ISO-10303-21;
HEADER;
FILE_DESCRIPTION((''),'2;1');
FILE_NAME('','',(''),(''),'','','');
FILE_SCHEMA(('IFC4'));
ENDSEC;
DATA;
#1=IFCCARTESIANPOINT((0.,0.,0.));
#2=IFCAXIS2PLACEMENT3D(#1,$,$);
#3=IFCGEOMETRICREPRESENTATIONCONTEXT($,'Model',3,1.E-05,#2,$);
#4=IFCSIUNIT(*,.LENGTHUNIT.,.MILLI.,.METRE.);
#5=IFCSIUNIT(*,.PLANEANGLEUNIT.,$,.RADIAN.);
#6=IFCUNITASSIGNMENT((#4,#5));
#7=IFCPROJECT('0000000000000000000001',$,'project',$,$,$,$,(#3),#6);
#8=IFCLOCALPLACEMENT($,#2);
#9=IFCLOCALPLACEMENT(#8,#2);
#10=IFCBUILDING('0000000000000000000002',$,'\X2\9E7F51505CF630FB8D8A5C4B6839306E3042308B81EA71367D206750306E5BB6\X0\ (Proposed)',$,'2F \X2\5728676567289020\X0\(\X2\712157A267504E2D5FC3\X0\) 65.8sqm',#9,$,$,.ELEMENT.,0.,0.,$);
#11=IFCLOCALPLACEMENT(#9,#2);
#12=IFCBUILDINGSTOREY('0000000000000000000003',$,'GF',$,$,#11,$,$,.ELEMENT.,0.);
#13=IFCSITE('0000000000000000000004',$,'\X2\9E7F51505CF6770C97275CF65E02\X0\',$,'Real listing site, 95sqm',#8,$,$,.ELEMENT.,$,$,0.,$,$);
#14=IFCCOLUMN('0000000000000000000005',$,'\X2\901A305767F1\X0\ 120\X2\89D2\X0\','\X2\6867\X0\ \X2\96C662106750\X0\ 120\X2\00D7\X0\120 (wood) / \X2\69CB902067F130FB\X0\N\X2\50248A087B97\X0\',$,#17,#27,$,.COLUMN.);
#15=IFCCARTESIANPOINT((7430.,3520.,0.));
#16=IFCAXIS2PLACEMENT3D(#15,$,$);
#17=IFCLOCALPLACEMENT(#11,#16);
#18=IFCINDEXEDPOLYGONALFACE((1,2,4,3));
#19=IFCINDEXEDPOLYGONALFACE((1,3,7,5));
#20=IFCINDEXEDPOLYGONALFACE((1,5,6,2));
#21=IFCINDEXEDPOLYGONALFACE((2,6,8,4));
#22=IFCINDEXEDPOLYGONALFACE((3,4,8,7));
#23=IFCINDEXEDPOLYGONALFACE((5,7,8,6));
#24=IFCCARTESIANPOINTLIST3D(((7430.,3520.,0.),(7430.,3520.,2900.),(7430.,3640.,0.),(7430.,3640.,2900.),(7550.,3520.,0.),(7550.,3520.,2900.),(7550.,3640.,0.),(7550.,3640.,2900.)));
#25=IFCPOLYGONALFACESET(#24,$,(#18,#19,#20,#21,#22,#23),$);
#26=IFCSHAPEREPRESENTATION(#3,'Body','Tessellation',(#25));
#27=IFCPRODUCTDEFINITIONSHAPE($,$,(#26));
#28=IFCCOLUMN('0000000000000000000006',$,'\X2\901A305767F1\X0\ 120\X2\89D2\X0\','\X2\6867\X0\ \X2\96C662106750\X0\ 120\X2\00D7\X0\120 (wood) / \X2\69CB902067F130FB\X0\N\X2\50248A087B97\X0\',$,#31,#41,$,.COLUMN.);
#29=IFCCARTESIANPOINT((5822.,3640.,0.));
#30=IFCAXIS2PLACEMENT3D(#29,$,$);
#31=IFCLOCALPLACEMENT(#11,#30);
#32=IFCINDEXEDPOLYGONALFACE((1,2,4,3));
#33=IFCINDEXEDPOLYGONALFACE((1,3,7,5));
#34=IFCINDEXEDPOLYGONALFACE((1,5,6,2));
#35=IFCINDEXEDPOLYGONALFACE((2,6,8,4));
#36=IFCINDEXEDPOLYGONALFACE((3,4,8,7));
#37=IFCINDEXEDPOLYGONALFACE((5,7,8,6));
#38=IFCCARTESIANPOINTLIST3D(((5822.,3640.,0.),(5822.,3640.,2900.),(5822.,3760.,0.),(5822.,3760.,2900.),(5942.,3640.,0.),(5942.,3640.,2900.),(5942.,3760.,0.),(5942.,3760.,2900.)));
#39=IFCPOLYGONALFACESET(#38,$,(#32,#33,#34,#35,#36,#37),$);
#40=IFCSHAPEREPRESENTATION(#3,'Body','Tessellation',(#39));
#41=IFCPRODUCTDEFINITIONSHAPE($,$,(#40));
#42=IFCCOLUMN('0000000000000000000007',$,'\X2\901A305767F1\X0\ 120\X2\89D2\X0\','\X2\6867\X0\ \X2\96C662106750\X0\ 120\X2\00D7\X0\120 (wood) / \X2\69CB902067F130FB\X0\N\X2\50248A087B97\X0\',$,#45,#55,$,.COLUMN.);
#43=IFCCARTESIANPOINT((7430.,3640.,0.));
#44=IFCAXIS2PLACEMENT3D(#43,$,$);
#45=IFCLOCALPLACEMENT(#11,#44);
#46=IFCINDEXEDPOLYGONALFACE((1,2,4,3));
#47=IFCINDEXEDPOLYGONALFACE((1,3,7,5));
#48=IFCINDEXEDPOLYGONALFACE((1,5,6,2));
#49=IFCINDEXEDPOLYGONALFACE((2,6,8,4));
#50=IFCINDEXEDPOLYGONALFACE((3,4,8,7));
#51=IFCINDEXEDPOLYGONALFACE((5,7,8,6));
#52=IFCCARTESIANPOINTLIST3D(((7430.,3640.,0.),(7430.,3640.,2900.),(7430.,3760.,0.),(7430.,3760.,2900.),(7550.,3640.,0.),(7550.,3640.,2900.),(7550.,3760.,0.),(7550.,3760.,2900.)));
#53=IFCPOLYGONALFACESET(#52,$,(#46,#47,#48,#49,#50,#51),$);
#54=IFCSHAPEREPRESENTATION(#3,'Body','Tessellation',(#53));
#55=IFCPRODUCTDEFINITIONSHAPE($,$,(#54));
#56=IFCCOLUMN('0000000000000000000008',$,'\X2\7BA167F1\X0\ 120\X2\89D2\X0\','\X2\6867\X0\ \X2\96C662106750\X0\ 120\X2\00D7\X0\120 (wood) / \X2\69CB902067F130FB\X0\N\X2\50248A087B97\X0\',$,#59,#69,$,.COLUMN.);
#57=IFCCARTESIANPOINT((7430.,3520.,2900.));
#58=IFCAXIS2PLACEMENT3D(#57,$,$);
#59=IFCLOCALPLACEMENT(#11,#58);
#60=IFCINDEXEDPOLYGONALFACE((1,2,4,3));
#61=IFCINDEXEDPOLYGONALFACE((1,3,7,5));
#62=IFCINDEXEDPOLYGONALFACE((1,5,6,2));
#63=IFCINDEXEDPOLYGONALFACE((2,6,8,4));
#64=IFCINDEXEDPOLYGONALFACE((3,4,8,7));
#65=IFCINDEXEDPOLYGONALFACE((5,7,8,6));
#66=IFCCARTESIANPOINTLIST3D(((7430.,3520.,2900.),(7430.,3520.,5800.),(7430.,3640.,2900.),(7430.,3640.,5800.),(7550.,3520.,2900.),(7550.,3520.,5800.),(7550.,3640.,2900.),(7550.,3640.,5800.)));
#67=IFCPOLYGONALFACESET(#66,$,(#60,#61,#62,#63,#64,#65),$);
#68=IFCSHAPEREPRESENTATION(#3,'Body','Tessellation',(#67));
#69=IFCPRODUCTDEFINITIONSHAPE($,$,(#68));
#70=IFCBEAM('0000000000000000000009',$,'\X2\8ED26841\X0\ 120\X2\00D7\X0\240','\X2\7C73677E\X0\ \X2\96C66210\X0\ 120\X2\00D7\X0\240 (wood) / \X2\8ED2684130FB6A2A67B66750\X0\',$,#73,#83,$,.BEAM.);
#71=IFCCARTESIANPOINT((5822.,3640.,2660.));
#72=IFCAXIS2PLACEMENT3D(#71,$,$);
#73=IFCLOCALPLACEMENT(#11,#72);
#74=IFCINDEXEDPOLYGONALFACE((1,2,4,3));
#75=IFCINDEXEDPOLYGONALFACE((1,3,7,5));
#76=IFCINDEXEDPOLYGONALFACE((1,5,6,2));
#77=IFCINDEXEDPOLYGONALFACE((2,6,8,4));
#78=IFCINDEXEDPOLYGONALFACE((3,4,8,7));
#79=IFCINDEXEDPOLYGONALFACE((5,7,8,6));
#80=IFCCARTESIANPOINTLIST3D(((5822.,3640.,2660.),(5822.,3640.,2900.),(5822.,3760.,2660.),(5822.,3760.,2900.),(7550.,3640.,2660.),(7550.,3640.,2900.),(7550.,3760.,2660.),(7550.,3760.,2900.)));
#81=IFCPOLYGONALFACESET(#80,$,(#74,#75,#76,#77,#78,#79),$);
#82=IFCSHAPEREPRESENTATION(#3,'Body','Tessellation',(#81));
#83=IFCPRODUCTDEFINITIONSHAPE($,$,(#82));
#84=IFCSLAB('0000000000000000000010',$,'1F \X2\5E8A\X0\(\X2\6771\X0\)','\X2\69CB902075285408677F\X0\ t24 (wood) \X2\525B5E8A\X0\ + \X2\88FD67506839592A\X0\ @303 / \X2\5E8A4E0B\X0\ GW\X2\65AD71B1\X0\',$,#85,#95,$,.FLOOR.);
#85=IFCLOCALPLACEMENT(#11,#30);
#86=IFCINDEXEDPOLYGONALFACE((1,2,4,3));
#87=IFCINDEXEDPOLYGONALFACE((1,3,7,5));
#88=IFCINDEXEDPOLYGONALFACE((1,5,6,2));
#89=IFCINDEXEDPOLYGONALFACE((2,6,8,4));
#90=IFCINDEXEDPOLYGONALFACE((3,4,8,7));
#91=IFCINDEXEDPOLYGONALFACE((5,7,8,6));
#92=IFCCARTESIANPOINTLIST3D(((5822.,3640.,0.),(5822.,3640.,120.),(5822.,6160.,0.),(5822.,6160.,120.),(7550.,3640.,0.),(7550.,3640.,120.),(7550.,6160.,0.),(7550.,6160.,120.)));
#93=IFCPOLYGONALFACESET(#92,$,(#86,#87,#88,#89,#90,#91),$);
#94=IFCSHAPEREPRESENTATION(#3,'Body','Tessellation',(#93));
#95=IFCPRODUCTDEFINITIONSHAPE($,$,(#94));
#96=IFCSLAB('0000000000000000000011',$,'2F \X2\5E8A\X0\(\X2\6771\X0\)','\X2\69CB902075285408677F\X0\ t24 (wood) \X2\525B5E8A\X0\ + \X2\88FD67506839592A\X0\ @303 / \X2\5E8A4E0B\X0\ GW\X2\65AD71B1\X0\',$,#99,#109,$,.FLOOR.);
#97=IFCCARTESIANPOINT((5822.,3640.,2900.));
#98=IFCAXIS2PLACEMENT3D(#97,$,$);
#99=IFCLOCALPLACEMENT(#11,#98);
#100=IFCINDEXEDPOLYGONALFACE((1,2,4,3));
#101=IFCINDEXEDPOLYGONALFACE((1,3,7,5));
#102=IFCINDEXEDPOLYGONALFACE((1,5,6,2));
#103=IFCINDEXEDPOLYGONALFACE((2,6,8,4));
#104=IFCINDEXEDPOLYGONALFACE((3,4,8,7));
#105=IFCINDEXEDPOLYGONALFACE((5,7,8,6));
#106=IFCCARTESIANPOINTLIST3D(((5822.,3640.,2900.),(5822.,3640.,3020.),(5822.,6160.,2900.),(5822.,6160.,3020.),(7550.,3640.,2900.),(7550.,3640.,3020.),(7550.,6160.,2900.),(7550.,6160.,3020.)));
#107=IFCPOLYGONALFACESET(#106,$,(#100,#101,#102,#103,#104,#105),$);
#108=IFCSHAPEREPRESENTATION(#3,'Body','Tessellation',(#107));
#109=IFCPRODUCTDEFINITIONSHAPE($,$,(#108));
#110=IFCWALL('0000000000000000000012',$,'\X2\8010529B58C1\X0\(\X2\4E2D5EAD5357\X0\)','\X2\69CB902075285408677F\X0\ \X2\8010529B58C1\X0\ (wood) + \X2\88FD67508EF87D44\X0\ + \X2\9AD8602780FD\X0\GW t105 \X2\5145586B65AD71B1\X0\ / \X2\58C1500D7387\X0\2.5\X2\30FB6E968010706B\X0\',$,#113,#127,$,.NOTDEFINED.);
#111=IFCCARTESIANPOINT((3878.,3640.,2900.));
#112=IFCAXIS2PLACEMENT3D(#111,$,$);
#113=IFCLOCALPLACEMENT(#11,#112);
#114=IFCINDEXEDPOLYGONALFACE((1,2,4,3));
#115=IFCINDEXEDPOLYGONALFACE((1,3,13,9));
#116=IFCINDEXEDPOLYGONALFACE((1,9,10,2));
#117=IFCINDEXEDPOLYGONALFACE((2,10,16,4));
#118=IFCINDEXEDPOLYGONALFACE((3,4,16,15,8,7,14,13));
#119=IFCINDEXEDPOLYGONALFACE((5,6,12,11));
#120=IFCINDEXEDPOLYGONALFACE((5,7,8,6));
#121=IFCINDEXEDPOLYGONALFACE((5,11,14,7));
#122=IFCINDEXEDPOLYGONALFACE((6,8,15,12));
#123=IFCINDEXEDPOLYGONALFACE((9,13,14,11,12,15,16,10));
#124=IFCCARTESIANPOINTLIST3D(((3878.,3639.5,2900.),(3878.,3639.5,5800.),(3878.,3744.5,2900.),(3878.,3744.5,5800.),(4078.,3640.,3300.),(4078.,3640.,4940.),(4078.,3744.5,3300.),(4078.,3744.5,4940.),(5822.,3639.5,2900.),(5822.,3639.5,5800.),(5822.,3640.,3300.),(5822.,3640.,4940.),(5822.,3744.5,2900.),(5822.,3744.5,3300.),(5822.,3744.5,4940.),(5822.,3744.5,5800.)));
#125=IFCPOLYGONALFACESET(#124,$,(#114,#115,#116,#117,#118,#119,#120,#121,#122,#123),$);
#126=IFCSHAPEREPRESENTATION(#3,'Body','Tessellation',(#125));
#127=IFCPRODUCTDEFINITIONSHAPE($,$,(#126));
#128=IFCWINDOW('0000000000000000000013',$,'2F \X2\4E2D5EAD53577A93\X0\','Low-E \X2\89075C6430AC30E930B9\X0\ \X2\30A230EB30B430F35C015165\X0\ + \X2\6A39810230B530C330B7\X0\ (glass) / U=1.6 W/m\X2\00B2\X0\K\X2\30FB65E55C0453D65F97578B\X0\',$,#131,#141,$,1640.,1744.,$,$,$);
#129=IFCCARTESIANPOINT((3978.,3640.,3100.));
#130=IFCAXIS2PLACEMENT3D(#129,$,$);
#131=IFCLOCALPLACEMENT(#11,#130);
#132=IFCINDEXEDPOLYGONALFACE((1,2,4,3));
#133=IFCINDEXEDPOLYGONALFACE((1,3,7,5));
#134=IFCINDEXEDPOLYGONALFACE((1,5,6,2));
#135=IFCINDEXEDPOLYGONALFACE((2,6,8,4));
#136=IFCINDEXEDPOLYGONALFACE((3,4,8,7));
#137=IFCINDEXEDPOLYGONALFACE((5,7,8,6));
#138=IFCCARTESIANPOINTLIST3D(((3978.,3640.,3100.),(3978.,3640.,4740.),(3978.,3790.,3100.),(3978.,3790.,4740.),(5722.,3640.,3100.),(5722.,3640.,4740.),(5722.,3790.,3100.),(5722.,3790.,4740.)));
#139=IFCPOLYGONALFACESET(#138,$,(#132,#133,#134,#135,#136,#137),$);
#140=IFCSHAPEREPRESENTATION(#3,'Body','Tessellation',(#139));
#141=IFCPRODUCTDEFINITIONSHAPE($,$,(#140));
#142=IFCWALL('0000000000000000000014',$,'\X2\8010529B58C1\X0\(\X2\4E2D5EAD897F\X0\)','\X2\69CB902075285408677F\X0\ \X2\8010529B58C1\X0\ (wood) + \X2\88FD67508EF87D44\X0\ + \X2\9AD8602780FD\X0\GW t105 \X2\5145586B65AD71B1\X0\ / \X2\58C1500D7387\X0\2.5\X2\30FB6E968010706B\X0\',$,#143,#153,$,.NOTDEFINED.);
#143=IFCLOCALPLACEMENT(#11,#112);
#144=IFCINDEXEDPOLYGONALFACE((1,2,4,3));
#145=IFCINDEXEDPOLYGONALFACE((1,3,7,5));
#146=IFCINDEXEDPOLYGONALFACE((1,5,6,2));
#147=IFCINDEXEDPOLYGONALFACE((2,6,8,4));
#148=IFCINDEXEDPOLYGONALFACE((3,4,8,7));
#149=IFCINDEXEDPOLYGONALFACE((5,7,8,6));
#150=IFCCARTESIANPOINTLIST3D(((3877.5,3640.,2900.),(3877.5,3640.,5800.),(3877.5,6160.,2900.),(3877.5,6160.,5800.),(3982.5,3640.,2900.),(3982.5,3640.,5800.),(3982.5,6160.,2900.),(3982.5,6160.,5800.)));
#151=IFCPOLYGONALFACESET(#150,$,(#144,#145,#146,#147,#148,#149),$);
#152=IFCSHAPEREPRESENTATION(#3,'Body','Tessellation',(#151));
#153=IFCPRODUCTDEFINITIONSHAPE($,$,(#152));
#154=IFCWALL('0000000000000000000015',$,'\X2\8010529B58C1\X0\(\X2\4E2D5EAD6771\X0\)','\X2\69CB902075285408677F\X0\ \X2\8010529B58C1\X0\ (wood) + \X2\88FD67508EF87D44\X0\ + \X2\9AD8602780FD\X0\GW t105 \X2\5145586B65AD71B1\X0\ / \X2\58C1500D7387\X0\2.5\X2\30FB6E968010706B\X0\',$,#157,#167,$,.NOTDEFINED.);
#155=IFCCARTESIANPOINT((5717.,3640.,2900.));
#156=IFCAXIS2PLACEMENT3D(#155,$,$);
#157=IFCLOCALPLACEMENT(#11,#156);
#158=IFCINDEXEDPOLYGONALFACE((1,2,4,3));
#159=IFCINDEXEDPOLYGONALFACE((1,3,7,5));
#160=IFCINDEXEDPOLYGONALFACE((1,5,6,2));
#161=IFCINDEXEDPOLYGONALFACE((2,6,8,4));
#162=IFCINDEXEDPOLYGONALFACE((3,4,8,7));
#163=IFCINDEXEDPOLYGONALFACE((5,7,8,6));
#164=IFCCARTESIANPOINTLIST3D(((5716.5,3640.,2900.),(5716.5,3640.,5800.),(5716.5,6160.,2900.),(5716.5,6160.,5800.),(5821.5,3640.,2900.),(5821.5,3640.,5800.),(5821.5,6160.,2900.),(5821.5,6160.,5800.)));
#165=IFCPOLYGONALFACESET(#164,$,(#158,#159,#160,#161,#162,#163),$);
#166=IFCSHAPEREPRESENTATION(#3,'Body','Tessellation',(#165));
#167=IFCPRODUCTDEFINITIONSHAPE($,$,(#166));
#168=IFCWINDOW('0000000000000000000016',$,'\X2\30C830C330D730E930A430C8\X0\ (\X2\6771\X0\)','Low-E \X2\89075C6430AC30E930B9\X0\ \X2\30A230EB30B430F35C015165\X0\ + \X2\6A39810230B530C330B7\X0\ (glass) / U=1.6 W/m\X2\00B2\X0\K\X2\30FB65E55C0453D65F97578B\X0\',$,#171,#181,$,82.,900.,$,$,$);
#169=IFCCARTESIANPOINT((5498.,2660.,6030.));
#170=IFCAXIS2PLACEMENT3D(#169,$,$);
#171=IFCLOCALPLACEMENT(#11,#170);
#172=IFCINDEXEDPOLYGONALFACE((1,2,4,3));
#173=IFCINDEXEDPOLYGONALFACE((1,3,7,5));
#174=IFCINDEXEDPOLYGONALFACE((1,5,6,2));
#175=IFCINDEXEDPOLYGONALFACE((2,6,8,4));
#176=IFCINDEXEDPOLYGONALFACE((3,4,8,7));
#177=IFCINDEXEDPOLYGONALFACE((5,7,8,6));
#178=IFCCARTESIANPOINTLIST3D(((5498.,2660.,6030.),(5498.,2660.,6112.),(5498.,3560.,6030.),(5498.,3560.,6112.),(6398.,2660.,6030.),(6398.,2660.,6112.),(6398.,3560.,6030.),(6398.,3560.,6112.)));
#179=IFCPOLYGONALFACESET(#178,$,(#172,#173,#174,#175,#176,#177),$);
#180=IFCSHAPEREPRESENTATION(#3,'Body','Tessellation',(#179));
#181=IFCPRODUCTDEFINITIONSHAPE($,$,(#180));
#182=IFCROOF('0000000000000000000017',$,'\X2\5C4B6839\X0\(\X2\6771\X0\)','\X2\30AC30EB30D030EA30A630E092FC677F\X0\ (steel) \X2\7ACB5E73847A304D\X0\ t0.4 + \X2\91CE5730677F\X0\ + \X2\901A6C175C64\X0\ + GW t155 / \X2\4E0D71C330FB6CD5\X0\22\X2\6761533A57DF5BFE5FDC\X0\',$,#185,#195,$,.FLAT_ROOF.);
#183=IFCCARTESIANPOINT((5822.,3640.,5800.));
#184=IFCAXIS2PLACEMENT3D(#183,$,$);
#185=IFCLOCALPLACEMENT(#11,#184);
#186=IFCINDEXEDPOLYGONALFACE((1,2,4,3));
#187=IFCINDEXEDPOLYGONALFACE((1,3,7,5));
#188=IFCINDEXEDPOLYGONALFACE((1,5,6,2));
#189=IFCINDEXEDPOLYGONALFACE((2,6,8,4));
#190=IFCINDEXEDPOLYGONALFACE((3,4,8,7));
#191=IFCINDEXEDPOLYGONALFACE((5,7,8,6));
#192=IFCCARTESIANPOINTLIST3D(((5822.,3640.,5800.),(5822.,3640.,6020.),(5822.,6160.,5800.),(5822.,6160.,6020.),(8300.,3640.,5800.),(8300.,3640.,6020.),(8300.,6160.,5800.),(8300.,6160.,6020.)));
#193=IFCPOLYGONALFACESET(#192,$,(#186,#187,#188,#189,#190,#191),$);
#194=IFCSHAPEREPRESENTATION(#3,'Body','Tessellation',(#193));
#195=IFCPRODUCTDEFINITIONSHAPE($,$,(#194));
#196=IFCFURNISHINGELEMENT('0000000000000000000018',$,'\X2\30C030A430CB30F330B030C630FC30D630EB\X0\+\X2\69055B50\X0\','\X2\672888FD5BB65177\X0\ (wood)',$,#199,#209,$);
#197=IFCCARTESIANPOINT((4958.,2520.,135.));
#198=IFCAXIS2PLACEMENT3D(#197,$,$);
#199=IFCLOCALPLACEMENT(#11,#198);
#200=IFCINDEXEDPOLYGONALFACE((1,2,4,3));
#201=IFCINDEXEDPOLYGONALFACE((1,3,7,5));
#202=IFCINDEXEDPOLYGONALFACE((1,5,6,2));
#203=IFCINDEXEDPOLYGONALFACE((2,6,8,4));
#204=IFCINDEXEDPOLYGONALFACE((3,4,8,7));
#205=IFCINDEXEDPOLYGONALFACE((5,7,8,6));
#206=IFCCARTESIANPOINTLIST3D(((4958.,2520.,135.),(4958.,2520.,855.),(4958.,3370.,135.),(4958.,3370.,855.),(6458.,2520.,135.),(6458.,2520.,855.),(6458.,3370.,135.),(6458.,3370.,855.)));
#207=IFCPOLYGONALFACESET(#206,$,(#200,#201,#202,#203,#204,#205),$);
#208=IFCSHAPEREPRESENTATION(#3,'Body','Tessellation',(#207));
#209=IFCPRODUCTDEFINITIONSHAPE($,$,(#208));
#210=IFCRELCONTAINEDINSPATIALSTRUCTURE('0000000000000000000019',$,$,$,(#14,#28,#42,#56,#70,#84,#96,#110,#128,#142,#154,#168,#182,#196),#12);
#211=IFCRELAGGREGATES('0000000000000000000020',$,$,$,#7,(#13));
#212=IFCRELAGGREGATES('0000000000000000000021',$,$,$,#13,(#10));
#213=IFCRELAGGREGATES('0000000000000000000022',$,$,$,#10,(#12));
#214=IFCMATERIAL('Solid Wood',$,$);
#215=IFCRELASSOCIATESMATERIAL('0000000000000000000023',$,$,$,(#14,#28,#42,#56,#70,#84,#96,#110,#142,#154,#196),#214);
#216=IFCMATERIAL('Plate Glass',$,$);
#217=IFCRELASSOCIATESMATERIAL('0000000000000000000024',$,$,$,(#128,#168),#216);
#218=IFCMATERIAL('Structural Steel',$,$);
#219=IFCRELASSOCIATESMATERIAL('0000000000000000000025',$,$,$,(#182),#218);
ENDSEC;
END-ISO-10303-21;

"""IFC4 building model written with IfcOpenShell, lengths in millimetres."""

from ifc_helpers import new_model, si_unit, frame, frame_2d, origin, place, context, project, spatial, rectangle, extrude, material, element, fill, save


model = new_model("IFC4")

# Units and contexts
model_context = context("Model", 3, precision=1e-05, world=origin())
ifc_project = project(units=[si_unit("LENGTHUNIT", "METRE", prefix="MILLI"), si_unit("PLANEANGLEUNIT", "RADIAN")], contexts=[model_context])

# Site, building, storey
site_placement = place(None, origin())
site = spatial("IfcSite", under=ifc_project, at=site_placement, Name="鹿児島県霧島市", ObjectType="Real listing site, 95sqm", CompositionType="ELEMENT", RefElevation=0.0)
building_placement = place(site_placement, origin())
building = spatial("IfcBuilding", under=site, at=building_placement, Name="鹿児島・越屋根のある自然素材の家 (Proposed)", ObjectType="2F 在来木造(無垢材中心) 65.8sqm", CompositionType="ELEMENT", ElevationOfRefHeight=0.0, ElevationOfTerrain=0.0)
storey_placement = place(building_placement, origin())
storey = spatial("IfcBuildingStorey", under=building, at=storey_placement, Name="GF", CompositionType="ELEMENT", Elevation=0.0)

# Columns
ifc_material_1 = material(Name="Solid Wood")
column_1_placement = place(storey_placement, frame((7430.0, 3520.0, 0.0)))
element("IfcColumn", 1, at=column_1_placement, inside=storey, material=ifc_material_1, Name="通し柱 120角", Description="桧 集成材 120×120 (wood) / 構造柱・N値計算", PredefinedType="COLUMN", context=model_context, shape_type="SweptSolid", body=[
    extrude(rectangle(XDim=120.0, YDim=120.0, at=frame_2d((60.0, 60.0))), frame((7430.0, 3520.0, 0.0)), (0.0, 0.0, 1.0), 2900.0),
])
column_2_placement = place(storey_placement, frame((5822.0, 3640.0, 0.0)))
element("IfcColumn", 2, at=column_2_placement, inside=storey, material=ifc_material_1, Name="通し柱 120角", Description="桧 集成材 120×120 (wood) / 構造柱・N値計算", PredefinedType="COLUMN", context=model_context, shape_type="SweptSolid", body=[
    extrude(rectangle(XDim=120.0, YDim=120.0, at=frame_2d((60.0, 60.0))), frame((5822.0, 3640.0, 0.0)), (0.0, 0.0, 1.0), 2900.0),
])
column_3_placement = place(storey_placement, frame((7430.0, 3640.0, 0.0)))
element("IfcColumn", 3, at=column_3_placement, inside=storey, material=ifc_material_1, Name="通し柱 120角", Description="桧 集成材 120×120 (wood) / 構造柱・N値計算", PredefinedType="COLUMN", context=model_context, shape_type="SweptSolid", body=[
    extrude(rectangle(XDim=120.0, YDim=120.0, at=frame_2d((60.0, 60.0))), frame((7430.0, 3640.0, 0.0)), (0.0, 0.0, 1.0), 2900.0),
])
column_4_placement = place(storey_placement, frame((7430.0, 3520.0, 2900.0)))
element("IfcColumn", 4, at=column_4_placement, inside=storey, material=ifc_material_1, Name="管柱 120角", Description="桧 集成材 120×120 (wood) / 構造柱・N値計算", PredefinedType="COLUMN", context=model_context, shape_type="SweptSolid", body=[
    extrude(rectangle(XDim=120.0, YDim=120.0, at=frame_2d((60.0, 60.0))), frame((7430.0, 3520.0, 2900.0)), (0.0, 0.0, 1.0), 2900.0),
])

# Beam
beam_1_placement = place(storey_placement, frame((5822.0, 3640.0, 2660.0)))
element("IfcBeam", 5, at=beam_1_placement, inside=storey, material=ifc_material_1, Name="軒桁 120×240", Description="米松 集成 120×240 (wood) / 軒桁・横架材", PredefinedType="BEAM", context=model_context, shape_type="SweptSolid", body=[
    extrude(rectangle(XDim=1728.0, YDim=120.0, at=frame_2d((864.0, 60.0))), frame((5822.0, 3640.0, 2660.0)), (0.0, 0.0, 1.0), 240.0),
])

# Slabs
slab_1_placement = place(storey_placement, frame((5822.0, 3640.0, 0.0)))
element("IfcSlab", 6, at=slab_1_placement, inside=storey, material=ifc_material_1, Name="1F 床(東)", Description="構造用合板 t24 (wood) 剛床 + 製材根太 @303 / 床下 GW断熱", PredefinedType="FLOOR", context=model_context, shape_type="SweptSolid", body=[
    extrude(rectangle(XDim=1728.0, YDim=2520.0, at=frame_2d((864.0, 1260.0))), frame((5822.0, 3640.0, 0.0)), (0.0, 0.0, 1.0), 120.0),
])
slab_2_placement = place(storey_placement, frame((5822.0, 3640.0, 2900.0)))
element("IfcSlab", 7, at=slab_2_placement, inside=storey, material=ifc_material_1, Name="2F 床(東)", Description="構造用合板 t24 (wood) 剛床 + 製材根太 @303 / 床下 GW断熱", PredefinedType="FLOOR", context=model_context, shape_type="SweptSolid", body=[
    extrude(rectangle(XDim=1728.0, YDim=2520.0, at=frame_2d((864.0, 1260.0))), frame((5822.0, 3640.0, 2900.0)), (0.0, 0.0, 1.0), 120.0),
])

# Wall, opening, window
wall_1_placement = place(storey_placement, frame((3878.0, 3640.0, 2900.0)))
wall_1 = element("IfcWall", 8, at=wall_1_placement, inside=storey, material=ifc_material_1, Name="耐力壁(中庭南)", Description="構造用合板 耐力壁 (wood) + 製材軸組 + 高性能GW t105 充填断熱 / 壁倍率2.5・準耐火", PredefinedType="NOTDEFINED", context=model_context, shape_type="SweptSolid", body=[
    extrude(rectangle(XDim=1944.0, YDim=105.0, at=frame_2d((972.0, 52.0))), frame((3878.0, 3640.0, 2900.0)), (0.0, 0.0, 1.0), 2900.0),
])
opening_placement = place(storey_placement, frame((3978.0, 3640.0, 3100.0)))
opening = element("IfcOpeningElement", 9, at=opening_placement, cuts=wall_1, PredefinedType="NOTDEFINED", context=model_context, shape_type="SweptSolid", body=[
    extrude(rectangle(XDim=1744.0, YDim=150.0, at=frame_2d((872.0, 75.0))), frame((3978.0, 3640.0, 3100.0)), (0.0, 0.0, 1.0), 1640.0),
])
ifc_material_2 = material(Name="Plate Glass")
window_1_placement = place(storey_placement, frame((3978.0, 3640.0, 3100.0)))
window_1 = element("IfcWindow", 10, at=window_1_placement, inside=storey, material=ifc_material_2, Name="2F 中庭南窓", Description="Low-E 複層ガラス アルゴン封入 + 樹脂サッシ (glass) / U=1.6 W/m²K・日射取得型", OverallHeight=1640.0, OverallWidth=1744.0, context=model_context, shape_type="SweptSolid", body=[
    extrude(rectangle(XDim=1744.0, YDim=150.0, at=frame_2d((872.0, 75.0))), frame((3978.0, 3640.0, 3100.0)), (0.0, 0.0, 1.0), 1640.0),
])
fill(opening, window_1)

# Walls
wall_2_placement = place(storey_placement, frame((3878.0, 3640.0, 2900.0)))
element("IfcWall", 11, at=wall_2_placement, inside=storey, material=ifc_material_1, Name="耐力壁(中庭西)", Description="構造用合板 耐力壁 (wood) + 製材軸組 + 高性能GW t105 充填断熱 / 壁倍率2.5・準耐火", PredefinedType="NOTDEFINED", context=model_context, shape_type="SweptSolid", body=[
    extrude(rectangle(XDim=105.0, YDim=2520.0, at=frame_2d((52.0, 1260.0))), frame((3878.0, 3640.0, 2900.0)), (0.0, 0.0, 1.0), 2900.0),
])
wall_3_placement = place(storey_placement, frame((5717.0, 3640.0, 2900.0)))
element("IfcWall", 12, at=wall_3_placement, inside=storey, material=ifc_material_1, Name="耐力壁(中庭東)", Description="構造用合板 耐力壁 (wood) + 製材軸組 + 高性能GW t105 充填断熱 / 壁倍率2.5・準耐火", PredefinedType="NOTDEFINED", context=model_context, shape_type="SweptSolid", body=[
    extrude(rectangle(XDim=105.0, YDim=2520.0, at=frame_2d((52.0, 1260.0))), frame((5717.0, 3640.0, 2900.0)), (0.0, 0.0, 1.0), 2900.0),
])

# Window
window_2_placement = place(storey_placement, frame((5498.0, 2660.0, 6030.0)))
element("IfcWindow", 13, at=window_2_placement, inside=storey, material=ifc_material_2, Name="トップライト (東)", Description="Low-E 複層ガラス アルゴン封入 + 樹脂サッシ (glass) / U=1.6 W/m²K・日射取得型", OverallHeight=82.0, OverallWidth=900.0, context=model_context, shape_type="SweptSolid", body=[
    extrude(rectangle(XDim=900.0, YDim=900.0, at=frame_2d((450.0, 450.0))), frame((5498.0, 2660.0, 6030.0)), (0.0, 0.0, 1.0), 82.0),
])

# Roof
ifc_material_3 = material(Name="Structural Steel")
for number, where, name in (
    (14, (5822.0, 3640.0, 5800.0), "屋根(東)"),
):
    element("IfcRoof", number, at=place(storey_placement, frame(where)), inside=storey, material=ifc_material_3, Name=name, Description="ガルバリウム鋼板 (steel) 立平葺き t0.4 + 野地板 + 通気層 + GW t155 / 不燃・法22条区域対応", PredefinedType="FLAT_ROOF", context=model_context, shape_type="SweptSolid", body=[
        extrude(rectangle(XDim=2478.0, YDim=2520.0, at=frame_2d((1239.0, 1260.0))), frame((5822.0, 3640.0, 5800.0)), (0.0, 0.0, 1.0), 220.0),
    ])

# Furnishing element
furnishing_1_placement = place(storey_placement, frame((4958.0, 2520.0, 135.0)))
element("IfcFurnishingElement", 15, at=furnishing_1_placement, inside=storey, material=ifc_material_1, Name="ダイニングテーブル+椅子", Description="木製家具 (wood)", context=model_context, shape_type="SweptSolid", body=[
    extrude(rectangle(XDim=1500.0, YDim=850.0, at=frame_2d((750.0, 425.0))), frame((4958.0, 2520.0, 135.0)), (0.0, 0.0, 1.0), 720.0),
])

save(model, "model.ifc")
